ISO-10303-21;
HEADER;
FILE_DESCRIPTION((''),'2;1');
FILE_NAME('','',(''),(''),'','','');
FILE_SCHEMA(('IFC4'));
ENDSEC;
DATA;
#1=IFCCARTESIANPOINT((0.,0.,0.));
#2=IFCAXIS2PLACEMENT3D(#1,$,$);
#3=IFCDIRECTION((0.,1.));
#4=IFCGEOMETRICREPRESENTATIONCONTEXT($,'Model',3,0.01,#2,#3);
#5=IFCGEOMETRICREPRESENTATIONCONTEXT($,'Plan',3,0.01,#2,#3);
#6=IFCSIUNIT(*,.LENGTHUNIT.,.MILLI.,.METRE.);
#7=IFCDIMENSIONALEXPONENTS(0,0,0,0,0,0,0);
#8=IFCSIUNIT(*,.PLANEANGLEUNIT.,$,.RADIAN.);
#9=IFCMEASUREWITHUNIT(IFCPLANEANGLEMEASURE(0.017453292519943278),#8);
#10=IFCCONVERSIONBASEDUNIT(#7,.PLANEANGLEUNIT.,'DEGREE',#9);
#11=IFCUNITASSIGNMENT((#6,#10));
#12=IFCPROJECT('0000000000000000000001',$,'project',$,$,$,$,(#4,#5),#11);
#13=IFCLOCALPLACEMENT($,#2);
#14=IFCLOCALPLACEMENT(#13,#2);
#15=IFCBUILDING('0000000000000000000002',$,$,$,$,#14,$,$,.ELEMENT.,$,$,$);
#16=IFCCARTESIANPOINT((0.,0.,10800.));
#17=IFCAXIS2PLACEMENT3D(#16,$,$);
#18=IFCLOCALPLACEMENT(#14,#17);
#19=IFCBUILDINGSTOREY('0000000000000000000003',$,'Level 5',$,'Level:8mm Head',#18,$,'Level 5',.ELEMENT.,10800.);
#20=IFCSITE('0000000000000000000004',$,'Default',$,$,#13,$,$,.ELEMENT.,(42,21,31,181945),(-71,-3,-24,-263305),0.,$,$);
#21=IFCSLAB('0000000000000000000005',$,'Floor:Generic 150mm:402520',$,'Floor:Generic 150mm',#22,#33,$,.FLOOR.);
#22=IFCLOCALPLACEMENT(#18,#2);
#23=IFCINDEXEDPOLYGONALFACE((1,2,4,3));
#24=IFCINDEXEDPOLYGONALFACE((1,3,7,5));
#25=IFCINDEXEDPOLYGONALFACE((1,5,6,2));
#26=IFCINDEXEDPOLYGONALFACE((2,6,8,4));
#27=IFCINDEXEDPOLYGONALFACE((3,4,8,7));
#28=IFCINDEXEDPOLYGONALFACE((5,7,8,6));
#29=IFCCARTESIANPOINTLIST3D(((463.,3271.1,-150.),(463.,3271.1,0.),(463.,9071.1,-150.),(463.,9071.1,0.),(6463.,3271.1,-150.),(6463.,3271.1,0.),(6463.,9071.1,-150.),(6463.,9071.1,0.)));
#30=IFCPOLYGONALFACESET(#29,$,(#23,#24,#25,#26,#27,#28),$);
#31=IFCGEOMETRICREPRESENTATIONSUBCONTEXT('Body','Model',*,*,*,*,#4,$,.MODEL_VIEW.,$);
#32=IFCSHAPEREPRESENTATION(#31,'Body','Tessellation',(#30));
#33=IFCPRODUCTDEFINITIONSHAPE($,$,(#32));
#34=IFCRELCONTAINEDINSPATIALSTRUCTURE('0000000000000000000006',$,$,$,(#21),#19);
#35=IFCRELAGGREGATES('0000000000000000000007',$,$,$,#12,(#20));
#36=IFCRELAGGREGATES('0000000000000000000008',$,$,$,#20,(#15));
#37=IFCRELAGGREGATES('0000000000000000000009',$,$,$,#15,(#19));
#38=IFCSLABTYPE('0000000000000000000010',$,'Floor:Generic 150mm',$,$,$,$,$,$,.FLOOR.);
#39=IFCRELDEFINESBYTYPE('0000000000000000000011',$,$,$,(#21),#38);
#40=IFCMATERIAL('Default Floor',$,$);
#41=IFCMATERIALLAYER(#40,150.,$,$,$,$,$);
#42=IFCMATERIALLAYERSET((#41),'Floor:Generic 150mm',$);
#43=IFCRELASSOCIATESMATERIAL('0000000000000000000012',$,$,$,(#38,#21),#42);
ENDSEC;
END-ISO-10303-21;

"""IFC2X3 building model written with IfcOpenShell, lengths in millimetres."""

from ifc_helpers import new_model, entity, si_unit, converted_unit, direction, frame, frame_2d, origin, place, context, subcontext, project, spatial, rectangle, extrude, material, layer, layer_set, layer_usage, type_object, element, save


model = new_model("IFC2X3")

# Units and contexts
model_context = context("Model", 3, precision=0.01, world=origin(), true_north=direction((0.0, 1.0)))
plan_context = context("Plan", 3, precision=0.01, world=origin(), true_north=direction((0.0, 1.0)))
body_context = subcontext(model_context, "Body", "Model", "MODEL_VIEW")
ifc_project = project(units=[si_unit("LENGTHUNIT", "METRE", prefix="MILLI"), converted_unit("PLANEANGLEUNIT", "DEGREE", entity("IfcPlaneAngleMeasure", 0.017453292519943278), si_unit("PLANEANGLEUNIT", "RADIAN"), dimensions=[0, 0, 0, 0, 0, 0, 0])], contexts=[model_context, plan_context])

# Site, building, storey
site_placement = place(None, origin())
site = spatial("IfcSite", under=ifc_project, at=site_placement, Name="Default", CompositionType="ELEMENT", RefLatitude=(42, 21, 31, 181945), RefLongitude=(-71, -3, -24, -263305), RefElevation=0.0)
building_placement = place(site_placement, origin())
building = spatial("IfcBuilding", under=site, at=building_placement, CompositionType="ELEMENT")
storey_placement = place(building_placement, frame((0.0, 0.0, 10800.0)))
storey = spatial("IfcBuildingStorey", under=building, at=storey_placement, Name="Level 5", ObjectType="Level:8mm Head", LongName="Level 5", CompositionType="ELEMENT", Elevation=10800.0)

# Slab
ifc_material = material(Name="Default Floor")
ifc_layer = layer(ifc_material, 150.0)
ifc_layer_set = layer_set([ifc_layer], Name="Floor:Generic 150mm")
ifc_layer_usage = layer_usage(ifc_layer_set, "AXIS3", "POSITIVE", 0.0)
slab_type = type_object("IfcSlabType", Name="Floor:Generic 150mm", PredefinedType="FLOOR", material=ifc_layer_set)
slab_placement = place(storey_placement, origin())
element("IfcSlab", 1, at=slab_placement, inside=storey, type_object=slab_type, material=ifc_layer_usage, Name="Floor:Generic 150mm:402520", ObjectType="Floor:Generic 150mm", PredefinedType="FLOOR", context=body_context, shape_type="SweptSolid", body=[
    extrude(rectangle(XDim=5800.0, YDim=6000.0, at=frame_2d((0.0, 0.0), x_axis=(1.0, 0.0))), frame((3463.0, 6171.1, 0.0), z_axis=(0.0, 0.0, -1.0), x_axis=(0.0, 1.0, 0.0)), (0.0, 0.0, 1.0), 150.0),
])

save(model, "model.ifc")
